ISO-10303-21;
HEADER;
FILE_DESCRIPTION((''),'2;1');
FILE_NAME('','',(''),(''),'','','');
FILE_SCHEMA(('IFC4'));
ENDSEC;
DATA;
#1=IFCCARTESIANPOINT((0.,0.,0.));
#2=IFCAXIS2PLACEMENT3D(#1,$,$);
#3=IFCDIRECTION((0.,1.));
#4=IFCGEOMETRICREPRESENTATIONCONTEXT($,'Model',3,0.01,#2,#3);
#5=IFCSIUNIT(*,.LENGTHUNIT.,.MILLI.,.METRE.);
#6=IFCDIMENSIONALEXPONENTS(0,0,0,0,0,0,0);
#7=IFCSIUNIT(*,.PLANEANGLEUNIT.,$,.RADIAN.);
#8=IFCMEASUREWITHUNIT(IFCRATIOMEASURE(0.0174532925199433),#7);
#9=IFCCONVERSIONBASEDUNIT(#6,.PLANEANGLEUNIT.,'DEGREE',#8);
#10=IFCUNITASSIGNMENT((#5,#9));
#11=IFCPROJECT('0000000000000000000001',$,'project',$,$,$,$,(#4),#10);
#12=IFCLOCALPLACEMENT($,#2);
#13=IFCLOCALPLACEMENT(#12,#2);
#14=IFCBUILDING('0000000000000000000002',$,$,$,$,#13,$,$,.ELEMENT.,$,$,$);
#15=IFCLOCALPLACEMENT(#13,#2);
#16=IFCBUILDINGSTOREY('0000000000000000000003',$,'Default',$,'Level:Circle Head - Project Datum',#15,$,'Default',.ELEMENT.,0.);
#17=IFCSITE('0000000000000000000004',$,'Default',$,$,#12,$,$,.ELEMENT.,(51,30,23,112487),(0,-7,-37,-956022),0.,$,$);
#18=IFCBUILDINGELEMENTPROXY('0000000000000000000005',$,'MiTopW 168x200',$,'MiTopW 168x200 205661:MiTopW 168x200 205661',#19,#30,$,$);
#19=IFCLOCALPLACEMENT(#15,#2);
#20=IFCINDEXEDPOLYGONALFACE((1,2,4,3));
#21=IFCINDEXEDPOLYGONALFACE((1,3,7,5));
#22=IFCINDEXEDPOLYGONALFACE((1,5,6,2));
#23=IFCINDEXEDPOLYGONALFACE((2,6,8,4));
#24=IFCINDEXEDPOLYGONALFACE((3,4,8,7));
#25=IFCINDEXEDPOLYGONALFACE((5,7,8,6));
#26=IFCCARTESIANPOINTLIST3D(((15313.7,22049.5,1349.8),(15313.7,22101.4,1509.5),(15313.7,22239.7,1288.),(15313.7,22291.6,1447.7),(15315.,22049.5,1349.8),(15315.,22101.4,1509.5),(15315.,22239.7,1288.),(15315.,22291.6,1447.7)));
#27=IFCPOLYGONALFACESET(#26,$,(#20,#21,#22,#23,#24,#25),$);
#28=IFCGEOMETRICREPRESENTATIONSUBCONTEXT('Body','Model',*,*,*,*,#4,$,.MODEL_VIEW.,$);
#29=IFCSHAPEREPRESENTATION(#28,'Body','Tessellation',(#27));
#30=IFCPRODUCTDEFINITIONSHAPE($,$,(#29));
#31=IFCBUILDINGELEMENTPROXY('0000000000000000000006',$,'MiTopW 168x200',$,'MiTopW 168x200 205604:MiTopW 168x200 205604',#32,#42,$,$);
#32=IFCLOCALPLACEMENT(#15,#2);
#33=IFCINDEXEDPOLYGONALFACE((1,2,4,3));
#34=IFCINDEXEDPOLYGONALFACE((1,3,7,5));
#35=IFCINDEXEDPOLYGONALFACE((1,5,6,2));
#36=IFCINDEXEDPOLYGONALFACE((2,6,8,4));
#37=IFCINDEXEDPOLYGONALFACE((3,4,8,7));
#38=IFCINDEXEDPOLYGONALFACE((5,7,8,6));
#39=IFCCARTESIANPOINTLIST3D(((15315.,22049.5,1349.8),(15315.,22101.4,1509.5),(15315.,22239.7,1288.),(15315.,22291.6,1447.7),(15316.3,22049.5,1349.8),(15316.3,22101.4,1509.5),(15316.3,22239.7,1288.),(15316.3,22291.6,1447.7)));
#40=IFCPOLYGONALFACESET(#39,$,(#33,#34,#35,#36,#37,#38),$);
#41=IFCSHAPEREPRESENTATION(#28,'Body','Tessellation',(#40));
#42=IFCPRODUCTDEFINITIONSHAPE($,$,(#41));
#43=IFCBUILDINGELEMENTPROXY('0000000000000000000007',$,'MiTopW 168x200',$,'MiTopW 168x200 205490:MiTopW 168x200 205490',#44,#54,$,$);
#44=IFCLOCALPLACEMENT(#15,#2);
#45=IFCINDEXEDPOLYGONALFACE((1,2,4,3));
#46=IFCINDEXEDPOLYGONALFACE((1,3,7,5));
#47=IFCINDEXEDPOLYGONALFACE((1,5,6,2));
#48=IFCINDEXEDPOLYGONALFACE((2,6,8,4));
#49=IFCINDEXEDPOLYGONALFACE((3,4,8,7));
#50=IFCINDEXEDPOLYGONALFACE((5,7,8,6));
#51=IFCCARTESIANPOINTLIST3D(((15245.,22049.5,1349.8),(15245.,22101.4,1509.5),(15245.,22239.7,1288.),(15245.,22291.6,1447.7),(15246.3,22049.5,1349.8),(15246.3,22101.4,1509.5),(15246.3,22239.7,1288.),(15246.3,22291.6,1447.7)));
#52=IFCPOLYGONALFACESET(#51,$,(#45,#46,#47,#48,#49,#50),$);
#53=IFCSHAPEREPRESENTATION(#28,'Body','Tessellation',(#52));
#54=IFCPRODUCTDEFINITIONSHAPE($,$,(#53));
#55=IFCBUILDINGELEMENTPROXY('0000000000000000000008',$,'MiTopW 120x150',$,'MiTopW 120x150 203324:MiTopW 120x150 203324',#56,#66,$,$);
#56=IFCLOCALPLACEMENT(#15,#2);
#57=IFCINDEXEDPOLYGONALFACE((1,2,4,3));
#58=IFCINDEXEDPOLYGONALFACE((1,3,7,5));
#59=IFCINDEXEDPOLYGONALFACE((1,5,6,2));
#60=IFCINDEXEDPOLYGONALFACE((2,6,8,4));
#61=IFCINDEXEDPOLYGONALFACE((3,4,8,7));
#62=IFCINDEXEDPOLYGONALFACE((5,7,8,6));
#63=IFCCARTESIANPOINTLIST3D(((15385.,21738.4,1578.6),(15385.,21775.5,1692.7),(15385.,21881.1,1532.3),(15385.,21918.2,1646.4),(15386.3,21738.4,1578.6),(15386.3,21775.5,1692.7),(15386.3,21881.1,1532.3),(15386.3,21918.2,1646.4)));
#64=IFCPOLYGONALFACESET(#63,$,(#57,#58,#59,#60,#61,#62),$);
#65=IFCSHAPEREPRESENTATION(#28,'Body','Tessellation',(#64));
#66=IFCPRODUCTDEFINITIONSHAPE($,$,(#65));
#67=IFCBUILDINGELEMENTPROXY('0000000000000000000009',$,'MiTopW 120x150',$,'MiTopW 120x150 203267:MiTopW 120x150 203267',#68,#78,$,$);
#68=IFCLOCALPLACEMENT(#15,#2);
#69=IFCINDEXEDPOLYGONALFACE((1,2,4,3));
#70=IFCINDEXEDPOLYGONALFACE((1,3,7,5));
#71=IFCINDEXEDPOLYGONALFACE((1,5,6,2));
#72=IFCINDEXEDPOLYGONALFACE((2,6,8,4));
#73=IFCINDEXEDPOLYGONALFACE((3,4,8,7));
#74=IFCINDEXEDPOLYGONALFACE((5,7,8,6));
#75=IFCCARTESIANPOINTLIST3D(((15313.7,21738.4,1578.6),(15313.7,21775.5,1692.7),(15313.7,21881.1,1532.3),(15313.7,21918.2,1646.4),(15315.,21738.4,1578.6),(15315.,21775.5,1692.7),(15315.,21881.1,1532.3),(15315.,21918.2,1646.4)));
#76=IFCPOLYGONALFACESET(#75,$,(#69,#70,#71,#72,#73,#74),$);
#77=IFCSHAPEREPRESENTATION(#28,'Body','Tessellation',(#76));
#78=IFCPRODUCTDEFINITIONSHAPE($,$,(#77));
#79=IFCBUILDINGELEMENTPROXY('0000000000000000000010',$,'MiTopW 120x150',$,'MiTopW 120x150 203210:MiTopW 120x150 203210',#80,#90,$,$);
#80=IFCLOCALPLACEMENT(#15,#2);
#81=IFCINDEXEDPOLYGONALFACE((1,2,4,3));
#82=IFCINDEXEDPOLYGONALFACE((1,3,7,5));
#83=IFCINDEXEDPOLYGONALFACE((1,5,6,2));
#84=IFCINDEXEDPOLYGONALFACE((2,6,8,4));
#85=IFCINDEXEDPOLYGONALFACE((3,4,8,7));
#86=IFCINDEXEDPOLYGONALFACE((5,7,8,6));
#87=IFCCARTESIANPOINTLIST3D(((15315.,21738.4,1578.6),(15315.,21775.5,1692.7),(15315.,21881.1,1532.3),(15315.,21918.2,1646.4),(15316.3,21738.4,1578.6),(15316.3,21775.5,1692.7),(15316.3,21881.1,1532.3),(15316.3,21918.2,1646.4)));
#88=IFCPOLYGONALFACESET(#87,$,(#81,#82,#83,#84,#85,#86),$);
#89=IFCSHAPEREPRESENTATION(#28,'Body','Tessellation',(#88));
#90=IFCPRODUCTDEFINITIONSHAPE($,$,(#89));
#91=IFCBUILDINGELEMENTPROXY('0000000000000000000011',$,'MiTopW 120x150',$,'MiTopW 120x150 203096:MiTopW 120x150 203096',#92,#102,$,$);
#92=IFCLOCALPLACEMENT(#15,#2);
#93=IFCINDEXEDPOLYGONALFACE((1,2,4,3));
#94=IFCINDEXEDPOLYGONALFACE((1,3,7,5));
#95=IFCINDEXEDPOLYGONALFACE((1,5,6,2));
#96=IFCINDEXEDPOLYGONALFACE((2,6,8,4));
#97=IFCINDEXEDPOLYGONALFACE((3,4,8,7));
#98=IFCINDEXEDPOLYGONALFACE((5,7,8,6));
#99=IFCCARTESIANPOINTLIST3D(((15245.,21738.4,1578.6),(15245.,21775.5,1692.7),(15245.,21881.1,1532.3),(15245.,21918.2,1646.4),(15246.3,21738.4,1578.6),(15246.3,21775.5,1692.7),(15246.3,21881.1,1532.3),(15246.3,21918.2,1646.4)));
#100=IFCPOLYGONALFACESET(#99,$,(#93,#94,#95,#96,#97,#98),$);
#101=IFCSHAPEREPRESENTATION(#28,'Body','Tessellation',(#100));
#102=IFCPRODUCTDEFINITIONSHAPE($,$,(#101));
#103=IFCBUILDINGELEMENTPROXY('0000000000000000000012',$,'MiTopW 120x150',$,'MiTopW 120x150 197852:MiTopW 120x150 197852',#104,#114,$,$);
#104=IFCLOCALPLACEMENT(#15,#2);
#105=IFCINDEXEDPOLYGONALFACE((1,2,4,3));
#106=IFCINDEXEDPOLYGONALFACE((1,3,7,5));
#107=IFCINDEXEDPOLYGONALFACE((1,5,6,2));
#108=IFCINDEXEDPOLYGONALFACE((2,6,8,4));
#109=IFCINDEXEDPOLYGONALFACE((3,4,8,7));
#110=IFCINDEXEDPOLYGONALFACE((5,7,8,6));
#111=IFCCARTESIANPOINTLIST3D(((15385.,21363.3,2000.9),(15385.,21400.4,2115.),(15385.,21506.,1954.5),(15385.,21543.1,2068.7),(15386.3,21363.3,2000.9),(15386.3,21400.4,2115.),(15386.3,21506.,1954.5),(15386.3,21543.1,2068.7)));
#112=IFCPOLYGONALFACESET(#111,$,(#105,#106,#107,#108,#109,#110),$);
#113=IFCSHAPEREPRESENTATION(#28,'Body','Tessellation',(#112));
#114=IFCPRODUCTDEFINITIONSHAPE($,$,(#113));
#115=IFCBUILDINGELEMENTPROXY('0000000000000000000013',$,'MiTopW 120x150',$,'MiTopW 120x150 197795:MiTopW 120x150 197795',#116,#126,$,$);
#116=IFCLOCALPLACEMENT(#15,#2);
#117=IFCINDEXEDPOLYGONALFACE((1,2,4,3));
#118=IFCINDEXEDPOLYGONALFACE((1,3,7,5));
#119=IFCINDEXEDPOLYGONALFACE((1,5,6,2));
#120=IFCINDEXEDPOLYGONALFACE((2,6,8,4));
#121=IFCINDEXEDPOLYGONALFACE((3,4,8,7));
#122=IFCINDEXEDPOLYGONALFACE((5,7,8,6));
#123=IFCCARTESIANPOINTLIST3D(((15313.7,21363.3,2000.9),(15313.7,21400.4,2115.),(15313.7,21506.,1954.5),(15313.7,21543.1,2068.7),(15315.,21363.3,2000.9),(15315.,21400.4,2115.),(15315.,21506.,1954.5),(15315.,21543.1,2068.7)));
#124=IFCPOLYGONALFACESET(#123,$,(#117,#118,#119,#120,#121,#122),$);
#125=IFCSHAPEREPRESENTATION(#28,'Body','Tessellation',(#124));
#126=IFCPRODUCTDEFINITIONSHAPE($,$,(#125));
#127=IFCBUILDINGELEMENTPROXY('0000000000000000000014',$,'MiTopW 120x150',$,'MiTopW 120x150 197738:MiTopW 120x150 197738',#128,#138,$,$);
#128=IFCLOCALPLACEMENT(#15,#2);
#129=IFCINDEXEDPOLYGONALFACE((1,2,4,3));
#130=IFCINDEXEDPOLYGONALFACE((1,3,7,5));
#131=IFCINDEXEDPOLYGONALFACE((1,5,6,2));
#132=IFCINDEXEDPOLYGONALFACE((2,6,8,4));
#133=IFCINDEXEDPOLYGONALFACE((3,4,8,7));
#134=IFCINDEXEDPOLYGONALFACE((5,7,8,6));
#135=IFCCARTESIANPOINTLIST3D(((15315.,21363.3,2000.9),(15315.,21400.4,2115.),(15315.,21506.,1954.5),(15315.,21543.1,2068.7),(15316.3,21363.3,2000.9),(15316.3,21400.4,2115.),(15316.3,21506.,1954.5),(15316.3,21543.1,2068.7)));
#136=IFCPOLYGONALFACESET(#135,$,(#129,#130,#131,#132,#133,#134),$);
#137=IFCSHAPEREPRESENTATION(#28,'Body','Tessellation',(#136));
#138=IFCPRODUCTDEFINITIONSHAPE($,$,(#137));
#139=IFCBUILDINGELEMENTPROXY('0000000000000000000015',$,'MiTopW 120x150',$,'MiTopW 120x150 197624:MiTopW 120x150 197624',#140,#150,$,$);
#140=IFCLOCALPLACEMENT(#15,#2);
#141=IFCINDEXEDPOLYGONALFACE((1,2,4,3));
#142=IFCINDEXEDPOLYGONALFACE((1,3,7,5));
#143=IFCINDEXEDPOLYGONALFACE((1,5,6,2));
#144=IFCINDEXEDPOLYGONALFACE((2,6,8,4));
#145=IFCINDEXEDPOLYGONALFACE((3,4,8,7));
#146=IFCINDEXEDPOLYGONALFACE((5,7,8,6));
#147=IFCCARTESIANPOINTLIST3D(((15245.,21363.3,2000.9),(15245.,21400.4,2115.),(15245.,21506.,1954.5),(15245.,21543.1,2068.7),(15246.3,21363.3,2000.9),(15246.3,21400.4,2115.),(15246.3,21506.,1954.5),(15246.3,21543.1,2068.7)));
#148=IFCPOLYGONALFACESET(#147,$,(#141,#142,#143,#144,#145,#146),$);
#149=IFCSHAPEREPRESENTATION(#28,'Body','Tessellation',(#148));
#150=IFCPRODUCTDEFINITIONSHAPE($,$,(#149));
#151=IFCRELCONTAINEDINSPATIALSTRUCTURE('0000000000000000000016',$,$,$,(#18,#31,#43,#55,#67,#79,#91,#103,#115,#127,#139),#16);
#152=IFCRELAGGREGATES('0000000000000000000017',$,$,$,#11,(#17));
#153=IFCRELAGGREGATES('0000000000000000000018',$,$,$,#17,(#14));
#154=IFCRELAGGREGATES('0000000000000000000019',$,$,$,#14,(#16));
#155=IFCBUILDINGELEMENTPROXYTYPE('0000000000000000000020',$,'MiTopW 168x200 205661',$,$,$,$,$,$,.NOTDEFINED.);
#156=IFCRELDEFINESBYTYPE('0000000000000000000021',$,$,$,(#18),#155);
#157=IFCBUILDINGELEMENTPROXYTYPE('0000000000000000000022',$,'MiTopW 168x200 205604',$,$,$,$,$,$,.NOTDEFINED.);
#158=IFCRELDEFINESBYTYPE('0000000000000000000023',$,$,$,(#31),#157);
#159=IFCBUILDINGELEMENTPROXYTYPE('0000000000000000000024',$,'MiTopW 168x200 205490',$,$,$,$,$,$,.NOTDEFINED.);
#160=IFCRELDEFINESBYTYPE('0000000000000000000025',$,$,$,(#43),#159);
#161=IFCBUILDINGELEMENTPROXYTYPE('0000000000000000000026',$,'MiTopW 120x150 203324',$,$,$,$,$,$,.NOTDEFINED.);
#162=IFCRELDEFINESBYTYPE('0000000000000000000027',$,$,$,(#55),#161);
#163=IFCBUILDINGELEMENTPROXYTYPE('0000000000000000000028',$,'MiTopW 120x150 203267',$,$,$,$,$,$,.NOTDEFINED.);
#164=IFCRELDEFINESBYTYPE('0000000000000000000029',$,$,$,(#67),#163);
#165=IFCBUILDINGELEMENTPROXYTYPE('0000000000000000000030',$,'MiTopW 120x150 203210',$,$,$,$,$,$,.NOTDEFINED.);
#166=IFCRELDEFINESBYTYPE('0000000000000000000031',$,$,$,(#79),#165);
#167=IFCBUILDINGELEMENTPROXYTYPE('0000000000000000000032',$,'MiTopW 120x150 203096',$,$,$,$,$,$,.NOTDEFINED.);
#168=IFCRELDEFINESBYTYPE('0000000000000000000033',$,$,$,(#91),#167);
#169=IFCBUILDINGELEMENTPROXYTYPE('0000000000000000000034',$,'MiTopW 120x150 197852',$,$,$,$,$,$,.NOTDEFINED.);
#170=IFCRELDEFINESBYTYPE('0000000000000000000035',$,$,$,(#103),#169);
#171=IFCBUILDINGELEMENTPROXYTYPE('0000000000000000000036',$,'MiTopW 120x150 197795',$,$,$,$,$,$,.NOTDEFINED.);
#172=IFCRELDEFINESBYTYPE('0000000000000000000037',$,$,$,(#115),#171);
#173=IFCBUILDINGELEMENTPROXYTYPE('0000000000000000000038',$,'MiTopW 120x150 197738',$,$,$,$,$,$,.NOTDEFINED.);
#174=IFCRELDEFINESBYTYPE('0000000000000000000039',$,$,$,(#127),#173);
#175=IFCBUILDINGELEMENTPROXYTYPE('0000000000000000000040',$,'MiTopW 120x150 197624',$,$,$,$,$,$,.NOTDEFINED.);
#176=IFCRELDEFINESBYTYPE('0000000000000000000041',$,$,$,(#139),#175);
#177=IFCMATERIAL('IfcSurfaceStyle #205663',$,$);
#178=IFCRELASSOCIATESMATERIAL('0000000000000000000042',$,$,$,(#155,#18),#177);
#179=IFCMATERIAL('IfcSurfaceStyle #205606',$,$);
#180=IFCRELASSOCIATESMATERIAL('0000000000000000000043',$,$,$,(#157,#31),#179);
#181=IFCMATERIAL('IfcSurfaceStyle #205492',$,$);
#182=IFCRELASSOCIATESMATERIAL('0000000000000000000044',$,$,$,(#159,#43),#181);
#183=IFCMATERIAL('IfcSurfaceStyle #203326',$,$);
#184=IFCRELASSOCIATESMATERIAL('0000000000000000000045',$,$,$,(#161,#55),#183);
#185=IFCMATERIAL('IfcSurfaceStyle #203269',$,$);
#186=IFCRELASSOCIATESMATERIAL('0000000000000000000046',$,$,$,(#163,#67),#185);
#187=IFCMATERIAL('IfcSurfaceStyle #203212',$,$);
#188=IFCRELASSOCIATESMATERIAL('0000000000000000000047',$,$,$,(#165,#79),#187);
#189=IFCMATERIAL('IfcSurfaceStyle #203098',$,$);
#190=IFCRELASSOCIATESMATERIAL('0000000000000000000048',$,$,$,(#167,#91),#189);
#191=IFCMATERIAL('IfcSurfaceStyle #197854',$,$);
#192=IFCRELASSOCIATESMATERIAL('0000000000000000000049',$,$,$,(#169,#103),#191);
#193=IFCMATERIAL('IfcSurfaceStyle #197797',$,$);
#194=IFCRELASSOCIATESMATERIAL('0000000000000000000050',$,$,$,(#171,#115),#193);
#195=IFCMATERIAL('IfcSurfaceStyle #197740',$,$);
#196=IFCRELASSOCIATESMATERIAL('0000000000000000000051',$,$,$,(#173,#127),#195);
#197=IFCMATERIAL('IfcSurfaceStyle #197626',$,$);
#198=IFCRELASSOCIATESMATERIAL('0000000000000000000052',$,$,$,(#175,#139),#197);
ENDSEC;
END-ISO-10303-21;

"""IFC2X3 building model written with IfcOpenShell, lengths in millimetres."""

from ifc_helpers import new_model, entity, si_unit, converted_unit, direction, frame, origin, place, context, subcontext, project, spatial, polyline, outline, extrude, source, transform, mapped, material, type_object, type_shapes, element, save


model = new_model("IFC2X3")

# Units and contexts
model_context = context("Model", 3, precision=0.01, world=origin(), true_north=direction((0.0, 1.0)))
body_context = subcontext(model_context, "Body", "Model", "MODEL_VIEW")
ifc_project = project(units=[si_unit("LENGTHUNIT", "METRE", prefix="MILLI"), converted_unit("PLANEANGLEUNIT", "DEGREE", entity("IfcRatioMeasure", 0.0174532925199433), si_unit("PLANEANGLEUNIT", "RADIAN"), dimensions=[0, 0, 0, 0, 0, 0, 0])], contexts=[model_context])

# Site, building, storey
site_placement = place(None, origin())
site = spatial("IfcSite", under=ifc_project, at=site_placement, Name="Default", CompositionType="ELEMENT", RefLatitude=(51, 30, 23, 112487), RefLongitude=(0, -7, -37, -956022), RefElevation=0.0)
building_placement = place(site_placement, origin())
building = spatial("IfcBuilding", under=site, at=building_placement, CompositionType="ELEMENT")
storey_placement = place(building_placement, origin())
storey = spatial("IfcBuildingStorey", under=building, at=storey_placement, Name="Default", ObjectType="Level:Circle Head - Project Datum", LongName="Default", CompositionType="ELEMENT", Elevation=0.0)

# Building element proxies
ifc_material_1 = material(Name="IfcSurfaceStyle #205663")
building_element_proxy_type_1 = type_object("IfcBuildingElementProxyType", Name="MiTopW 168x200 205661", PredefinedType="NOTDEFINED", material=ifc_material_1)
shared_shape_1 = source(origin(), body_context, "Body", "SweptSolid", [
    extrude(outline(polyline([(-100.0, -84.0), (100.0, -84.0), (100.0, 84.0), (-100.0, 84.0), (-100.0, -84.0)])), frame((100.0, 84.0, 0.0), z_axis=(0.0, 0.0, 1.0), x_axis=(-1.0, 0.0, 0.0)), (0.0, 0.0, 1.0), 1.3),
])
type_shapes(building_element_proxy_type_1, [shared_shape_1])
proxy_1_placement = place(building_placement, frame((15315.0, 22239.7, 1288.0), z_axis=(-1.0, 0.0, 0.0), x_axis=(0.0, -0.951057, 0.309017)))
element("IfcBuildingElementProxy", 1, at=proxy_1_placement, inside=storey, type_object=building_element_proxy_type_1, material=ifc_material_1, Name="MiTopW 168x200", ObjectType="MiTopW 168x200 205661:MiTopW 168x200 205661", context=body_context, shape_type="MappedRepresentation", body=[
    mapped(shared_shape_1, transform((0.0, 0.0, 0.0), scale=1.0)),
])
ifc_material_2 = material(Name="IfcSurfaceStyle #205606")
building_element_proxy_type_2 = type_object("IfcBuildingElementProxyType", Name="MiTopW 168x200 205604", PredefinedType="NOTDEFINED", material=ifc_material_2)
shared_shape_2 = source(origin(), body_context, "Body", "SweptSolid", [
    extrude(outline(polyline([(-100.0, -84.0), (100.0, -84.0), (100.0, 84.0), (-100.0, 84.0), (-100.0, -84.0)])), frame((100.0, 84.0, 0.0), z_axis=(0.0, 0.0, 1.0), x_axis=(-1.0, 0.0, 0.0)), (0.0, 0.0, 1.0), 1.3),
])
type_shapes(building_element_proxy_type_2, [shared_shape_2])
proxy_2_placement = place(building_placement, frame((15316.3, 22239.7, 1288.0), z_axis=(-1.0, 0.0, 0.0), x_axis=(0.0, -0.951057, 0.309017)))
element("IfcBuildingElementProxy", 2, at=proxy_2_placement, inside=storey, type_object=building_element_proxy_type_2, material=ifc_material_2, Name="MiTopW 168x200", ObjectType="MiTopW 168x200 205604:MiTopW 168x200 205604", context=body_context, shape_type="MappedRepresentation", body=[
    mapped(shared_shape_2, transform((0.0, 0.0, 0.0), scale=1.0)),
])
ifc_material_3 = material(Name="IfcSurfaceStyle #205492")
building_element_proxy_type_3 = type_object("IfcBuildingElementProxyType", Name="MiTopW 168x200 205490", PredefinedType="NOTDEFINED", material=ifc_material_3)
shared_shape_3 = source(origin(), body_context, "Body", "SweptSolid", [
    extrude(outline(polyline([(-100.0, -84.0), (100.0, -84.0), (100.0, 84.0), (-100.0, 84.0), (-100.0, -84.0)])), frame((100.0, 84.0, 0.0), z_axis=(0.0, 0.0, 1.0), x_axis=(-1.0, 0.0, 0.0)), (0.0, 0.0, 1.0), 1.3),
])
type_shapes(building_element_proxy_type_3, [shared_shape_3])
proxy_3_placement = place(building_placement, frame((15246.3, 22239.7, 1288.0), z_axis=(-1.0, 0.0, 0.0), x_axis=(0.0, -0.951057, 0.309017)))
element("IfcBuildingElementProxy", 3, at=proxy_3_placement, inside=storey, type_object=building_element_proxy_type_3, material=ifc_material_3, Name="MiTopW 168x200", ObjectType="MiTopW 168x200 205490:MiTopW 168x200 205490", context=body_context, shape_type="MappedRepresentation", body=[
    mapped(shared_shape_3, transform((0.0, 0.0, 0.0), scale=1.0)),
])
ifc_material_4 = material(Name="IfcSurfaceStyle #203326")
building_element_proxy_type_4 = type_object("IfcBuildingElementProxyType", Name="MiTopW 120x150 203324", PredefinedType="NOTDEFINED", material=ifc_material_4)
shared_shape_4 = source(origin(), body_context, "Body", "SweptSolid", [
    extrude(outline(polyline([(-75.0, -60.0), (75.0, -60.0), (75.0, 60.0), (-75.0, 60.0), (-75.0, -60.0)])), frame((75.0, 60.0, 0.0), z_axis=(0.0, 0.0, 1.0), x_axis=(-1.0, 0.0, 0.0)), (0.0, 0.0, 1.0), 1.3),
])
type_shapes(building_element_proxy_type_4, [shared_shape_4])
proxy_4_placement = place(building_placement, frame((15386.3, 21881.1, 1532.3), z_axis=(-1.0, 0.0, 0.0), x_axis=(0.0, -0.951057, 0.309017)))
element("IfcBuildingElementProxy", 4, at=proxy_4_placement, inside=storey, type_object=building_element_proxy_type_4, material=ifc_material_4, Name="MiTopW 120x150", ObjectType="MiTopW 120x150 203324:MiTopW 120x150 203324", context=body_context, shape_type="MappedRepresentation", body=[
    mapped(shared_shape_4, transform((0.0, 0.0, 0.0), scale=1.0)),
])
ifc_material_5 = material(Name="IfcSurfaceStyle #203269")
building_element_proxy_type_5 = type_object("IfcBuildingElementProxyType", Name="MiTopW 120x150 203267", PredefinedType="NOTDEFINED", material=ifc_material_5)
shared_shape_5 = source(origin(), body_context, "Body", "SweptSolid", [
    extrude(outline(polyline([(-75.0, -60.0), (75.0, -60.0), (75.0, 60.0), (-75.0, 60.0), (-75.0, -60.0)])), frame((75.0, 60.0, 0.0), z_axis=(0.0, 0.0, 1.0), x_axis=(-1.0, 0.0, 0.0)), (0.0, 0.0, 1.0), 1.3),
])
type_shapes(building_element_proxy_type_5, [shared_shape_5])
proxy_5_placement = place(building_placement, frame((15315.0, 21881.1, 1532.3), z_axis=(-1.0, 0.0, 0.0), x_axis=(0.0, -0.951057, 0.309017)))
element("IfcBuildingElementProxy", 5, at=proxy_5_placement, inside=storey, type_object=building_element_proxy_type_5, material=ifc_material_5, Name="MiTopW 120x150", ObjectType="MiTopW 120x150 203267:MiTopW 120x150 203267", context=body_context, shape_type="MappedRepresentation", body=[
    mapped(shared_shape_5, transform((0.0, 0.0, 0.0), scale=1.0)),
])
ifc_material_6 = material(Name="IfcSurfaceStyle #203212")
building_element_proxy_type_6 = type_object("IfcBuildingElementProxyType", Name="MiTopW 120x150 203210", PredefinedType="NOTDEFINED", material=ifc_material_6)
shared_shape_6 = source(origin(), body_context, "Body", "SweptSolid", [
    extrude(outline(polyline([(-75.0, -60.0), (75.0, -60.0), (75.0, 60.0), (-75.0, 60.0), (-75.0, -60.0)])), frame((75.0, 60.0, 0.0), z_axis=(0.0, 0.0, 1.0), x_axis=(-1.0, 0.0, 0.0)), (0.0, 0.0, 1.0), 1.3),
])
type_shapes(building_element_proxy_type_6, [shared_shape_6])
proxy_6_placement = place(building_placement, frame((15316.3, 21881.1, 1532.3), z_axis=(-1.0, 0.0, 0.0), x_axis=(0.0, -0.951057, 0.309017)))
element("IfcBuildingElementProxy", 6, at=proxy_6_placement, inside=storey, type_object=building_element_proxy_type_6, material=ifc_material_6, Name="MiTopW 120x150", ObjectType="MiTopW 120x150 203210:MiTopW 120x150 203210", context=body_context, shape_type="MappedRepresentation", body=[
    mapped(shared_shape_6, transform((0.0, 0.0, 0.0), scale=1.0)),
])
ifc_material_7 = material(Name="IfcSurfaceStyle #203098")
building_element_proxy_type_7 = type_object("IfcBuildingElementProxyType", Name="MiTopW 120x150 203096", PredefinedType="NOTDEFINED", material=ifc_material_7)
shared_shape_7 = source(origin(), body_context, "Body", "SweptSolid", [
    extrude(outline(polyline([(-75.0, -60.0), (75.0, -60.0), (75.0, 60.0), (-75.0, 60.0), (-75.0, -60.0)])), frame((75.0, 60.0, 0.0), z_axis=(0.0, 0.0, 1.0), x_axis=(-1.0, 0.0, 0.0)), (0.0, 0.0, 1.0), 1.3),
])
type_shapes(building_element_proxy_type_7, [shared_shape_7])
proxy_7_placement = place(building_placement, frame((15246.3, 21881.1, 1532.3), z_axis=(-1.0, 0.0, 0.0), x_axis=(0.0, -0.951057, 0.309017)))
element("IfcBuildingElementProxy", 7, at=proxy_7_placement, inside=storey, type_object=building_element_proxy_type_7, material=ifc_material_7, Name="MiTopW 120x150", ObjectType="MiTopW 120x150 203096:MiTopW 120x150 203096", context=body_context, shape_type="MappedRepresentation", body=[
    mapped(shared_shape_7, transform((0.0, 0.0, 0.0), scale=1.0)),
])
ifc_material_8 = material(Name="IfcSurfaceStyle #197854")
building_element_proxy_type_8 = type_object("IfcBuildingElementProxyType", Name="MiTopW 120x150 197852", PredefinedType="NOTDEFINED", material=ifc_material_8)
shared_shape_8 = source(origin(), body_context, "Body", "SweptSolid", [
    extrude(outline(polyline([(-75.0, -60.0), (75.0, -60.0), (75.0, 60.0), (-75.0, 60.0), (-75.0, -60.0)])), frame((75.0, 60.0, 0.0), z_axis=(0.0, 0.0, 1.0), x_axis=(-1.0, 0.0, 0.0)), (0.0, 0.0, 1.0), 1.3),
])
type_shapes(building_element_proxy_type_8, [shared_shape_8])
proxy_8_placement = place(building_placement, frame((15386.3, 21506.0, 1954.5), z_axis=(-1.0, 0.0, 0.0), x_axis=(0.0, -0.951057, 0.309017)))
element("IfcBuildingElementProxy", 8, at=proxy_8_placement, inside=storey, type_object=building_element_proxy_type_8, material=ifc_material_8, Name="MiTopW 120x150", ObjectType="MiTopW 120x150 197852:MiTopW 120x150 197852", context=body_context, shape_type="MappedRepresentation", body=[
    mapped(shared_shape_8, transform((0.0, 0.0, 0.0), scale=1.0)),
])
ifc_material_9 = material(Name="IfcSurfaceStyle #197797")
building_element_proxy_type_9 = type_object("IfcBuildingElementProxyType", Name="MiTopW 120x150 197795", PredefinedType="NOTDEFINED", material=ifc_material_9)
shared_shape_9 = source(origin(), body_context, "Body", "SweptSolid", [
    extrude(outline(polyline([(-75.0, -60.0), (75.0, -60.0), (75.0, 60.0), (-75.0, 60.0), (-75.0, -60.0)])), frame((75.0, 60.0, 0.0), z_axis=(0.0, 0.0, 1.0), x_axis=(-1.0, 0.0, 0.0)), (0.0, 0.0, 1.0), 1.3),
])
type_shapes(building_element_proxy_type_9, [shared_shape_9])
proxy_9_placement = place(building_placement, frame((15315.0, 21506.0, 1954.5), z_axis=(-1.0, 0.0, 0.0), x_axis=(0.0, -0.951057, 0.309017)))
element("IfcBuildingElementProxy", 9, at=proxy_9_placement, inside=storey, type_object=building_element_proxy_type_9, material=ifc_material_9, Name="MiTopW 120x150", ObjectType="MiTopW 120x150 197795:MiTopW 120x150 197795", context=body_context, shape_type="MappedRepresentation", body=[
    mapped(shared_shape_9, transform((0.0, 0.0, 0.0), scale=1.0)),
])
ifc_material_10 = material(Name="IfcSurfaceStyle #197740")
building_element_proxy_type_10 = type_object("IfcBuildingElementProxyType", Name="MiTopW 120x150 197738", PredefinedType="NOTDEFINED", material=ifc_material_10)
shared_shape_10 = source(origin(), body_context, "Body", "SweptSolid", [
    extrude(outline(polyline([(-75.0, -60.0), (75.0, -60.0), (75.0, 60.0), (-75.0, 60.0), (-75.0, -60.0)])), frame((75.0, 60.0, 0.0), z_axis=(0.0, 0.0, 1.0), x_axis=(-1.0, 0.0, 0.0)), (0.0, 0.0, 1.0), 1.3),
])
type_shapes(building_element_proxy_type_10, [shared_shape_10])
proxy_10_placement = place(building_placement, frame((15316.3, 21506.0, 1954.5), z_axis=(-1.0, 0.0, 0.0), x_axis=(0.0, -0.951057, 0.309017)))
element("IfcBuildingElementProxy", 10, at=proxy_10_placement, inside=storey, type_object=building_element_proxy_type_10, material=ifc_material_10, Name="MiTopW 120x150", ObjectType="MiTopW 120x150 197738:MiTopW 120x150 197738", context=body_context, shape_type="MappedRepresentation", body=[
    mapped(shared_shape_10, transform((0.0, 0.0, 0.0), scale=1.0)),
])
ifc_material_11 = material(Name="IfcSurfaceStyle #197626")
building_element_proxy_type_11 = type_object("IfcBuildingElementProxyType", Name="MiTopW 120x150 197624", PredefinedType="NOTDEFINED", material=ifc_material_11)
shared_shape_11 = source(origin(), body_context, "Body", "SweptSolid", [
    extrude(outline(polyline([(-75.0, -60.0), (75.0, -60.0), (75.0, 60.0), (-75.0, 60.0), (-75.0, -60.0)])), frame((75.0, 60.0, 0.0), z_axis=(0.0, 0.0, 1.0), x_axis=(-1.0, 0.0, 0.0)), (0.0, 0.0, 1.0), 1.3),
])
type_shapes(building_element_proxy_type_11, [shared_shape_11])
proxy_11_placement = place(building_placement, frame((15246.3, 21506.0, 1954.5), z_axis=(-1.0, 0.0, 0.0), x_axis=(0.0, -0.951057, 0.309017)))
element("IfcBuildingElementProxy", 11, at=proxy_11_placement, inside=storey, type_object=building_element_proxy_type_11, material=ifc_material_11, Name="MiTopW 120x150", ObjectType="MiTopW 120x150 197624:MiTopW 120x150 197624", context=body_context, shape_type="MappedRepresentation", body=[
    mapped(shared_shape_11, transform((0.0, 0.0, 0.0), scale=1.0)),
])

save(model, "model.ifc")
